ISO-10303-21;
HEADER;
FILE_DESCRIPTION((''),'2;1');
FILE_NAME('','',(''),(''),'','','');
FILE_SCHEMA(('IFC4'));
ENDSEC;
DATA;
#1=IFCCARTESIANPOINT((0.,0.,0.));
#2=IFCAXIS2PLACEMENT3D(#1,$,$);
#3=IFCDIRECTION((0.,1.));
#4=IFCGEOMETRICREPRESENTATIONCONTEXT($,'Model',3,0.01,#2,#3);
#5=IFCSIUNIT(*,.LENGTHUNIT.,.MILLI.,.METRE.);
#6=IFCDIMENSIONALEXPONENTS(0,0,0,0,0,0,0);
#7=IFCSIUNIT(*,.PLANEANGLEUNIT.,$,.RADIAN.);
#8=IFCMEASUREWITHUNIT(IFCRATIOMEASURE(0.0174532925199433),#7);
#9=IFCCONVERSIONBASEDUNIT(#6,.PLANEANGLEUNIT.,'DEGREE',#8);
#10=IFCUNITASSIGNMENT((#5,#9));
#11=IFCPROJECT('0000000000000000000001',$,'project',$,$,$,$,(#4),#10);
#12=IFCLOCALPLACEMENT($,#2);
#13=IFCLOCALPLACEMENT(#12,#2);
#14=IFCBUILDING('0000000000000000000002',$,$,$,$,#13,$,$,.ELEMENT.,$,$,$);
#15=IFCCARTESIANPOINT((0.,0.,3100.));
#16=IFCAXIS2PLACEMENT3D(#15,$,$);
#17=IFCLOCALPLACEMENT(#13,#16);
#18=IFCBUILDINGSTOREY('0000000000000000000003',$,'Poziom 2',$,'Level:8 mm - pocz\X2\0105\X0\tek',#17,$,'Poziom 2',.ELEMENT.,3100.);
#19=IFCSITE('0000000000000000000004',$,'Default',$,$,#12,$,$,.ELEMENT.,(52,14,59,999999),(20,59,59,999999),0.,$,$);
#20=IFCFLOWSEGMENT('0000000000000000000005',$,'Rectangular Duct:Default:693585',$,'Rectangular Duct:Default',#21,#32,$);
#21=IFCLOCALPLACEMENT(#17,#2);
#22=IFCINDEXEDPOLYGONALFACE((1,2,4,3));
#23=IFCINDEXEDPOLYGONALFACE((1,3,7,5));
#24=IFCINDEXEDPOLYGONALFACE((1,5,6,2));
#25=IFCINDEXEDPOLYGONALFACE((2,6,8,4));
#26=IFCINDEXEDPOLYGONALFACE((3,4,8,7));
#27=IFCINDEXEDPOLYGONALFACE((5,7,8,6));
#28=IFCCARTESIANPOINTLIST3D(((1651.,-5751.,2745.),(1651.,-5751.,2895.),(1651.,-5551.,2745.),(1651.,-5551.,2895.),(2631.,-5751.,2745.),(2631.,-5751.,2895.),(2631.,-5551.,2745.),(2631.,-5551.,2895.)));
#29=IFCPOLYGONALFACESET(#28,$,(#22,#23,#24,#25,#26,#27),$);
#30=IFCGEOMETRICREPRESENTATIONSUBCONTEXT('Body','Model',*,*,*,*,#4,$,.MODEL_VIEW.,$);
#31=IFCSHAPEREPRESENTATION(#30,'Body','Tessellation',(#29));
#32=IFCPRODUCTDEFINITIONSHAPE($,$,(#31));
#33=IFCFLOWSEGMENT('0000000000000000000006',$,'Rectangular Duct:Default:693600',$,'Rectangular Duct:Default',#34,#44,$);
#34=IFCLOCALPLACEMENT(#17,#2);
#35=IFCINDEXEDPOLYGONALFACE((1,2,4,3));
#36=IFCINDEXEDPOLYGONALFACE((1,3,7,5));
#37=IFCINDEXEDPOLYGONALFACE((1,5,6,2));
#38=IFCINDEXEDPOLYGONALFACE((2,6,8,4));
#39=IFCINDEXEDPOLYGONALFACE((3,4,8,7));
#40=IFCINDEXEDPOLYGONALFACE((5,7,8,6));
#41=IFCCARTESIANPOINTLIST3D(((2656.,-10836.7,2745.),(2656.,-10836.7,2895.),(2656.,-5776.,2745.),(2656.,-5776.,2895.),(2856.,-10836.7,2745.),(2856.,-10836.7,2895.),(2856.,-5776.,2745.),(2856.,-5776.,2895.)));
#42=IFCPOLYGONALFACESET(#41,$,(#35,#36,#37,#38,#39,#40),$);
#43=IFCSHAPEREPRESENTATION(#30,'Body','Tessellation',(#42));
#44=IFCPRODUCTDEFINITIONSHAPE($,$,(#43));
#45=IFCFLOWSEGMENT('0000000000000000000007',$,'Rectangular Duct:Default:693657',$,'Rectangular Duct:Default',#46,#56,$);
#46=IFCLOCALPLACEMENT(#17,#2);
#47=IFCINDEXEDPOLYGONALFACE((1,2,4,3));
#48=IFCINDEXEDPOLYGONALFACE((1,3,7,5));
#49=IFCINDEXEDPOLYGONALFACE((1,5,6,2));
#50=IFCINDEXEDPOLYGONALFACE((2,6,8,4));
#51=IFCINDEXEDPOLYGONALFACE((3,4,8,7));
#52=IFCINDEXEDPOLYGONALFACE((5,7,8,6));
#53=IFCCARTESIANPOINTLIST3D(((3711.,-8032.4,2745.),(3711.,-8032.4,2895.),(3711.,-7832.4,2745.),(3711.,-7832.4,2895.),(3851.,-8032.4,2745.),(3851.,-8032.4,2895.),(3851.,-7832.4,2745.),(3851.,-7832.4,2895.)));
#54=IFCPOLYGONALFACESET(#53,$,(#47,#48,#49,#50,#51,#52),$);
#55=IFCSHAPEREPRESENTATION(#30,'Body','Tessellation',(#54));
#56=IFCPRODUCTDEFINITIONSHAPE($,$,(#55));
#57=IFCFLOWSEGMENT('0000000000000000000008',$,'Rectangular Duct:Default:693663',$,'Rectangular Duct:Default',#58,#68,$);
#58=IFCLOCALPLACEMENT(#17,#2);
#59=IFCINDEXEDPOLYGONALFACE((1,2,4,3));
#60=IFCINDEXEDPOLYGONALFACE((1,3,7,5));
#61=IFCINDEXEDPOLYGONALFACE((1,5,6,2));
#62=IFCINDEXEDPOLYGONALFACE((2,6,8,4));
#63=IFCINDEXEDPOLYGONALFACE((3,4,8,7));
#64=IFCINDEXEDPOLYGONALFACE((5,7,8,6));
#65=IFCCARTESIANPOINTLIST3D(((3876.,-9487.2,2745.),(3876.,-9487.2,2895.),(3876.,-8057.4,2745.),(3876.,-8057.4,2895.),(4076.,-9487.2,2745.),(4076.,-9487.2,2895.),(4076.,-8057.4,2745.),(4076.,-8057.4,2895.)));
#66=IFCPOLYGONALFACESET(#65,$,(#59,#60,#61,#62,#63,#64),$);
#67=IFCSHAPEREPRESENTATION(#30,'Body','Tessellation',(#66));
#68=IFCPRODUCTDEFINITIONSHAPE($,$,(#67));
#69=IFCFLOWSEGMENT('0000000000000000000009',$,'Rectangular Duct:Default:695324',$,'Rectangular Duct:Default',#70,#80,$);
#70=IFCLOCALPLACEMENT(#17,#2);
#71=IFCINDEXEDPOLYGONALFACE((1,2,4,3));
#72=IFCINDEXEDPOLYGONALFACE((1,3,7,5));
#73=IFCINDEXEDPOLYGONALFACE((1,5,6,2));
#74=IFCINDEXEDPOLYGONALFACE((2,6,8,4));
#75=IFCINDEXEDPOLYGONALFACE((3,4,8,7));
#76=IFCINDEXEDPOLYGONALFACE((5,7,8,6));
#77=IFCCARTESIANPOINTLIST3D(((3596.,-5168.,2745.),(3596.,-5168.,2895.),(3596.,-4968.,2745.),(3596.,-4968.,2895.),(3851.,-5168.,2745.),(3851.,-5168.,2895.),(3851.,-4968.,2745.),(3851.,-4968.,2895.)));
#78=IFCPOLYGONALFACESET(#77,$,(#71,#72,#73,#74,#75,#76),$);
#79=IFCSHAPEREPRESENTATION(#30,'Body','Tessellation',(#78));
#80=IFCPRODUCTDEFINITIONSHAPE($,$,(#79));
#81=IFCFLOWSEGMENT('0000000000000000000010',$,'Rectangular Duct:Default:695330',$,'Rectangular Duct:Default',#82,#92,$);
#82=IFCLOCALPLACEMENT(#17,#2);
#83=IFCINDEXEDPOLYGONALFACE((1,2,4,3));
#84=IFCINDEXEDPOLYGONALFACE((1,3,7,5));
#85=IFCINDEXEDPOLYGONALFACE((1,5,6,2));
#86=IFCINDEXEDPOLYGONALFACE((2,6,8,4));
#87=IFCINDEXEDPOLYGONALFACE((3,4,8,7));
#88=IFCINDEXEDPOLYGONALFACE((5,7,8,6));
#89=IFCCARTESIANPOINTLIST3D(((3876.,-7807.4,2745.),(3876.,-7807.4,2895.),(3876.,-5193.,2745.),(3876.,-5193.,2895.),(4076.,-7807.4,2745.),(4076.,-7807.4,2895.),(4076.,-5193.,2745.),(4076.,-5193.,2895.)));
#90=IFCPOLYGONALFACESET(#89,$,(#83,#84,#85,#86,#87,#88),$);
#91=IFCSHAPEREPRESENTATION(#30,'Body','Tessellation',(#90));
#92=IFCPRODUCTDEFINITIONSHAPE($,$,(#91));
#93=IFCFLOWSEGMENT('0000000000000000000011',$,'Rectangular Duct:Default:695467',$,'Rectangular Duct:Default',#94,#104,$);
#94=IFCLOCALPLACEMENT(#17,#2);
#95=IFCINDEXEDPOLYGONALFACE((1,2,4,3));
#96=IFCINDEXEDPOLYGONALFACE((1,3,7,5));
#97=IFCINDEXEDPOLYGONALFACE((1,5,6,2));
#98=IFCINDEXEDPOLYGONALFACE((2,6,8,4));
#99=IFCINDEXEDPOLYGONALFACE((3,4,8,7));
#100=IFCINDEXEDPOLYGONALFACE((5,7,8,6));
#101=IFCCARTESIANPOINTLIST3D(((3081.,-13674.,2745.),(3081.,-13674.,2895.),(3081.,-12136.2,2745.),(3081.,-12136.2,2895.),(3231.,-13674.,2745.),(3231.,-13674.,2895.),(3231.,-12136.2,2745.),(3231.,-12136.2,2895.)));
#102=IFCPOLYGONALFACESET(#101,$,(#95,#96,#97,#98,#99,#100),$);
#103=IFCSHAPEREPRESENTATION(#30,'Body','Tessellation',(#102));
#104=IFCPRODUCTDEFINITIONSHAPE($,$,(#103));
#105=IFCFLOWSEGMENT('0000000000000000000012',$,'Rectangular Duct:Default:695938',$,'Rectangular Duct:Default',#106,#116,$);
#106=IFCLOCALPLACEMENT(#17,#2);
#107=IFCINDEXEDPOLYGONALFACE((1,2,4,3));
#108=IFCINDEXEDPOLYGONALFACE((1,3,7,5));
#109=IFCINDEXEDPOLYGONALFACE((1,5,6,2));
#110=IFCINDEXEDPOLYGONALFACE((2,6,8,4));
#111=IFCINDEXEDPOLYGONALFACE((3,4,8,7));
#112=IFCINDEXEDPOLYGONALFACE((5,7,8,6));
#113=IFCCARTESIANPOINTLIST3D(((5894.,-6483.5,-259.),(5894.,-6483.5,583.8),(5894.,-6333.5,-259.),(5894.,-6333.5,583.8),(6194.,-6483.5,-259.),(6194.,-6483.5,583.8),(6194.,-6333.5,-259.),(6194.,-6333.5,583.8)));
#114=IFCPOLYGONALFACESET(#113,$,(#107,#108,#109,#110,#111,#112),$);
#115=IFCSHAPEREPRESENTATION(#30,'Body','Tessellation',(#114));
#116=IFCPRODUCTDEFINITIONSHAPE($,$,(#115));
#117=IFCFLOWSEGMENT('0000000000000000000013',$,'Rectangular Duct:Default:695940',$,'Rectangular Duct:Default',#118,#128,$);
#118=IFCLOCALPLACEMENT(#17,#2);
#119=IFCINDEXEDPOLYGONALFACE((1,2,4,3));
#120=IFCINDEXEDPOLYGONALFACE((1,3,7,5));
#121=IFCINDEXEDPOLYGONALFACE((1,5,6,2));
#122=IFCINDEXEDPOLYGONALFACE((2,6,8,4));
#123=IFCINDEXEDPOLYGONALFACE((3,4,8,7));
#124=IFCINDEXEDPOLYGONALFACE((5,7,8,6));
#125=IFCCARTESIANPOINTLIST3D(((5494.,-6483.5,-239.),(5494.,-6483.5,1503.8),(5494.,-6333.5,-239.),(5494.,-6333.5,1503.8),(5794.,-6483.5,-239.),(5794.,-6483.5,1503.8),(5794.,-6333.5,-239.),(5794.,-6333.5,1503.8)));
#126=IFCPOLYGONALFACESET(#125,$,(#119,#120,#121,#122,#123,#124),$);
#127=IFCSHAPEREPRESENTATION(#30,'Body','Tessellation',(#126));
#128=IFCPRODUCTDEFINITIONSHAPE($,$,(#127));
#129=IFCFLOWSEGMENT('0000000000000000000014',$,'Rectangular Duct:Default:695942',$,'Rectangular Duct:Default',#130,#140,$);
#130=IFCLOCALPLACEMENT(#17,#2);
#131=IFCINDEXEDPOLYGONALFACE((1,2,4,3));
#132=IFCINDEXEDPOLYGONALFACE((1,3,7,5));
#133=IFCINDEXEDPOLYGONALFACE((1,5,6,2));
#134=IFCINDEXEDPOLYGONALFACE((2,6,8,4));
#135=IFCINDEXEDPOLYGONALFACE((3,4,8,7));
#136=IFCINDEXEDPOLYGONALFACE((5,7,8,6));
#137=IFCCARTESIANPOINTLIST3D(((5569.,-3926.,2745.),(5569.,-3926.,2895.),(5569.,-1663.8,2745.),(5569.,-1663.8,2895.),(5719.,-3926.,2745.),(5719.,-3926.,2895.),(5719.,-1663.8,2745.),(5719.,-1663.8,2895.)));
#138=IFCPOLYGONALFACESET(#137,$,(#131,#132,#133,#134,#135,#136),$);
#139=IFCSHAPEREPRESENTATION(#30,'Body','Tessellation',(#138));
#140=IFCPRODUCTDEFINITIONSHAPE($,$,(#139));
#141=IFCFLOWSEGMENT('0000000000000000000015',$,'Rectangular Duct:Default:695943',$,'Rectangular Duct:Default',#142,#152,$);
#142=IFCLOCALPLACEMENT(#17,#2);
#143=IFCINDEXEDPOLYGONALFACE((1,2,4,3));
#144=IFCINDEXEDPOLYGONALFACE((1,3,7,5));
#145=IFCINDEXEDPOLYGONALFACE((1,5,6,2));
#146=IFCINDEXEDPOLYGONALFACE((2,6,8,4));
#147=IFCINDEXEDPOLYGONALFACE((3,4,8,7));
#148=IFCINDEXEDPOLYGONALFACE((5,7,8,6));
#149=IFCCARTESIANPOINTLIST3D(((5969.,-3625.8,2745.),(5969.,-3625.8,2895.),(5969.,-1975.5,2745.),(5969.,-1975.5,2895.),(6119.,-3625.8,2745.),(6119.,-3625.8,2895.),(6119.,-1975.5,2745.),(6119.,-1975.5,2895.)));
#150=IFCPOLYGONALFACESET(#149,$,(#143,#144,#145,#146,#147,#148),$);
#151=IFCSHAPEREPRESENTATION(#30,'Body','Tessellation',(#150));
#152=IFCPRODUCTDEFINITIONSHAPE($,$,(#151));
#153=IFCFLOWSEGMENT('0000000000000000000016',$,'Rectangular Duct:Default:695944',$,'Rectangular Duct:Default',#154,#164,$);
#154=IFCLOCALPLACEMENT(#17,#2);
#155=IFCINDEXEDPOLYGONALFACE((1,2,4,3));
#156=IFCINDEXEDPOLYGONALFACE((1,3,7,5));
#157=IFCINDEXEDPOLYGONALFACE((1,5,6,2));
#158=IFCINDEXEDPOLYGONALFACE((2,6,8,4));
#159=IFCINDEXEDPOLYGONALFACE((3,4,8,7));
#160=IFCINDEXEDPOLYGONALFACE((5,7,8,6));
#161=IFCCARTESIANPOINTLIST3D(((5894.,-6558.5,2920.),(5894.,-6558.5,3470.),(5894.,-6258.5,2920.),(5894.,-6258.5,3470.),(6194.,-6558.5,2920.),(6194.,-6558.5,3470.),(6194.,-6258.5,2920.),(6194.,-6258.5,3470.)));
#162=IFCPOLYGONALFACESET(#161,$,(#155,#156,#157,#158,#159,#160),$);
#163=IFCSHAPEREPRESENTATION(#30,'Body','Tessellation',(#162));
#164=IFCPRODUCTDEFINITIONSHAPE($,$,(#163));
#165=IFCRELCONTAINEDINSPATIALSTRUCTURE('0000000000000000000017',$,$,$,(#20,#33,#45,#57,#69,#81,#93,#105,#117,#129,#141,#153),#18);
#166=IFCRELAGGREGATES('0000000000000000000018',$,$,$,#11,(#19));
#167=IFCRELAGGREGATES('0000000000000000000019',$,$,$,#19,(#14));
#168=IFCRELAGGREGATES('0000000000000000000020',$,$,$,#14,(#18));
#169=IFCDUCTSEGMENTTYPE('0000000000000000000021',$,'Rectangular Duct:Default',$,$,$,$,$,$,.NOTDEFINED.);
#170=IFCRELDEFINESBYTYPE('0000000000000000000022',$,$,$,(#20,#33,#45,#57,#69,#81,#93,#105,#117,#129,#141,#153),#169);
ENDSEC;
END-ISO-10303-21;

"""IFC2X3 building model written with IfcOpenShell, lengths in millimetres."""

from ifc_helpers import new_model, entity, si_unit, converted_unit, direction, frame, frame_2d, origin, origin_2d_with_axis, place, context, subcontext, project, spatial, rectangle, extrude, type_object, element, save


model = new_model("IFC2X3")

# Units and contexts
model_context = context("Model", 3, precision=0.01, world=origin(), true_north=direction((0.0, 1.0)))
body_context = subcontext(model_context, "Body", "Model", "MODEL_VIEW")
ifc_project = project(units=[si_unit("LENGTHUNIT", "METRE", prefix="MILLI"), converted_unit("PLANEANGLEUNIT", "DEGREE", entity("IfcRatioMeasure", 0.0174532925199433), si_unit("PLANEANGLEUNIT", "RADIAN"), dimensions=[0, 0, 0, 0, 0, 0, 0])], contexts=[model_context])

# Site, building, storey
site_placement = place(None, origin())
site = spatial("IfcSite", under=ifc_project, at=site_placement, Name="Default", CompositionType="ELEMENT", RefLatitude=(52, 14, 59, 999999), RefLongitude=(20, 59, 59, 999999), RefElevation=0.0)
building_placement = place(site_placement, origin())
building = spatial("IfcBuilding", under=site, at=building_placement, CompositionType="ELEMENT")
storey_placement = place(building_placement, frame((0.0, 0.0, 3100.0)))
storey = spatial("IfcBuildingStorey", under=building, at=storey_placement, Name="Poziom 2", ObjectType="Level:8 mm - początek", LongName="Poziom 2", CompositionType="ELEMENT", Elevation=3100.0)

# Flow segments
duct_segment_type = type_object("IfcDuctSegmentType", Name="Rectangular Duct:Default", PredefinedType="NOTDEFINED")
flow_segment_1_placement = place(storey_placement, origin())
element("IfcFlowSegment", 1, at=flow_segment_1_placement, inside=storey, type_object=duct_segment_type, Name="Rectangular Duct:Default:693585", ObjectType="Rectangular Duct:Default", context=body_context, shape_type="SweptSolid", body=[
    extrude(rectangle(XDim=980.0, YDim=200.0, at=frame_2d((0.0, 0.0), x_axis=(1.0, 0.0))), frame((2141.0, -5651.0, 2745.0), z_axis=(0.0, 0.0, 1.0), x_axis=(-1.0, 0.0, 0.0)), (0.0, 0.0, 1.0), 150.0),
])
flow_segment_2_placement = place(storey_placement, origin())
element("IfcFlowSegment", 2, at=flow_segment_2_placement, inside=storey, type_object=duct_segment_type, Name="Rectangular Duct:Default:693600", ObjectType="Rectangular Duct:Default", context=body_context, shape_type="SweptSolid", body=[
    extrude(rectangle(XDim=5060.7, YDim=200.0, at=frame_2d((0.0, 0.0), x_axis=(1.0, 0.0))), frame((2756.0, -8306.4, 2745.0), z_axis=(0.0, 0.0, 1.0), x_axis=(0.0, 1.0, 0.0)), (0.0, 0.0, 1.0), 150.0),
])
flow_segment_3_placement = place(storey_placement, origin())
element("IfcFlowSegment", 3, at=flow_segment_3_placement, inside=storey, type_object=duct_segment_type, Name="Rectangular Duct:Default:693657", ObjectType="Rectangular Duct:Default", context=body_context, shape_type="SweptSolid", body=[
    extrude(rectangle(XDim=140.0, YDim=200.0, at=frame_2d((0.0, 0.0), x_axis=(1.0, 0.0))), frame((3781.0, -7932.4, 2745.0), z_axis=(0.0, 0.0, 1.0), x_axis=(-1.0, 0.0, 0.0)), (0.0, 0.0, 1.0), 150.0),
])
flow_segment_4_placement = place(storey_placement, origin())
element("IfcFlowSegment", 4, at=flow_segment_4_placement, inside=storey, type_object=duct_segment_type, Name="Rectangular Duct:Default:693663", ObjectType="Rectangular Duct:Default", context=body_context, shape_type="SweptSolid", body=[
    extrude(rectangle(XDim=1429.8, YDim=200.0, at=origin_2d_with_axis()), frame((3976.0, -8772.3, 2745.0), z_axis=(0.0, 0.0, 1.0), x_axis=(0.0, 1.0, 0.0)), (0.0, 0.0, 1.0), 150.0),
])
flow_segment_5_placement = place(storey_placement, origin())
element("IfcFlowSegment", 5, at=flow_segment_5_placement, inside=storey, type_object=duct_segment_type, Name="Rectangular Duct:Default:695324", ObjectType="Rectangular Duct:Default", context=body_context, shape_type="SweptSolid", body=[
    extrude(rectangle(XDim=255.0, YDim=200.0, at=origin_2d_with_axis()), frame((3723.5, -5068.0, 2745.0), z_axis=(0.0, 0.0, 1.0), x_axis=(-1.0, 0.0, 0.0)), (0.0, 0.0, 1.0), 150.0),
])
flow_segment_6_placement = place(storey_placement, origin())
element("IfcFlowSegment", 6, at=flow_segment_6_placement, inside=storey, type_object=duct_segment_type, Name="Rectangular Duct:Default:695330", ObjectType="Rectangular Duct:Default", context=body_context, shape_type="SweptSolid", body=[
    extrude(rectangle(XDim=2614.4, YDim=200.0, at=frame_2d((0.0, 0.0), x_axis=(1.0, 0.0))), frame((3976.0, -6500.2, 2745.0), z_axis=(0.0, 0.0, 1.0), x_axis=(0.0, 1.0, 0.0)), (0.0, 0.0, 1.0), 150.0),
])
flow_segment_7_placement = place(storey_placement, origin())
element("IfcFlowSegment", 7, at=flow_segment_7_placement, inside=storey, type_object=duct_segment_type, Name="Rectangular Duct:Default:695467", ObjectType="Rectangular Duct:Default", context=body_context, shape_type="SweptSolid", body=[
    extrude(rectangle(XDim=1537.8, YDim=150.0, at=frame_2d((0.0, 0.0), x_axis=(1.0, 0.0))), frame((3156.0, -12905.1, 2745.0), z_axis=(0.0, 0.0, 1.0), x_axis=(0.0, -1.0, 0.0)), (0.0, 0.0, 1.0), 150.0),
])
flow_segment_8_placement = place(storey_placement, origin())
element("IfcFlowSegment", 8, at=flow_segment_8_placement, inside=storey, type_object=duct_segment_type, Name="Rectangular Duct:Default:695938", ObjectType="Rectangular Duct:Default", context=body_context, shape_type="SweptSolid", body=[
    extrude(rectangle(XDim=150.0, YDim=300.0, at=frame_2d((0.0, 0.0), x_axis=(1.0, 0.0))), frame((6044.0, -6408.5, -259.0), z_axis=(0.0, 0.0, 1.0), x_axis=(0.0, -1.0, 0.0)), (0.0, 0.0, 1.0), 842.8),
])
flow_segment_9_placement = place(storey_placement, origin())
element("IfcFlowSegment", 9, at=flow_segment_9_placement, inside=storey, type_object=duct_segment_type, Name="Rectangular Duct:Default:695940", ObjectType="Rectangular Duct:Default", context=body_context, shape_type="SweptSolid", body=[
    extrude(rectangle(XDim=150.0, YDim=300.0, at=frame_2d((0.0, 0.0), x_axis=(1.0, 0.0))), frame((5644.0, -6408.5, -239.0), z_axis=(0.0, 0.0, 1.0), x_axis=(0.0, -1.0, 0.0)), (0.0, 0.0, 1.0), 1742.8),
])
flow_segment_10_placement = place(storey_placement, origin())
element("IfcFlowSegment", 10, at=flow_segment_10_placement, inside=storey, type_object=duct_segment_type, Name="Rectangular Duct:Default:695942", ObjectType="Rectangular Duct:Default", context=body_context, shape_type="SweptSolid", body=[
    extrude(rectangle(XDim=2262.2, YDim=150.0, at=frame_2d((0.0, 0.0), x_axis=(1.0, 0.0))), frame((5644.0, -2794.9, 2745.0), z_axis=(0.0, 0.0, 1.0), x_axis=(0.0, 1.0, 0.0)), (0.0, 0.0, 1.0), 150.0),
])
flow_segment_11_placement = place(storey_placement, origin())
element("IfcFlowSegment", 11, at=flow_segment_11_placement, inside=storey, type_object=duct_segment_type, Name="Rectangular Duct:Default:695943", ObjectType="Rectangular Duct:Default", context=body_context, shape_type="SweptSolid", body=[
    extrude(rectangle(XDim=1650.4, YDim=150.0, at=origin_2d_with_axis()), frame((6044.0, -2800.6, 2745.0), z_axis=(0.0, 0.0, 1.0), x_axis=(0.0, 1.0, 0.0)), (0.0, 0.0, 1.0), 150.0),
])
flow_segment_12_placement = place(storey_placement, origin())
element("IfcFlowSegment", 12, at=flow_segment_12_placement, inside=storey, type_object=duct_segment_type, Name="Rectangular Duct:Default:695944", ObjectType="Rectangular Duct:Default", context=body_context, shape_type="SweptSolid", body=[
    extrude(rectangle(XDim=300.0, YDim=300.0, at=frame_2d((0.0, 0.0), x_axis=(1.0, 0.0))), frame((6044.0, -6408.5, 2920.0), z_axis=(0.0, 0.0, 1.0), x_axis=(0.0, 1.0, 0.0)), (0.0, 0.0, 1.0), 550.0),
])

save(model, "model.ifc")
